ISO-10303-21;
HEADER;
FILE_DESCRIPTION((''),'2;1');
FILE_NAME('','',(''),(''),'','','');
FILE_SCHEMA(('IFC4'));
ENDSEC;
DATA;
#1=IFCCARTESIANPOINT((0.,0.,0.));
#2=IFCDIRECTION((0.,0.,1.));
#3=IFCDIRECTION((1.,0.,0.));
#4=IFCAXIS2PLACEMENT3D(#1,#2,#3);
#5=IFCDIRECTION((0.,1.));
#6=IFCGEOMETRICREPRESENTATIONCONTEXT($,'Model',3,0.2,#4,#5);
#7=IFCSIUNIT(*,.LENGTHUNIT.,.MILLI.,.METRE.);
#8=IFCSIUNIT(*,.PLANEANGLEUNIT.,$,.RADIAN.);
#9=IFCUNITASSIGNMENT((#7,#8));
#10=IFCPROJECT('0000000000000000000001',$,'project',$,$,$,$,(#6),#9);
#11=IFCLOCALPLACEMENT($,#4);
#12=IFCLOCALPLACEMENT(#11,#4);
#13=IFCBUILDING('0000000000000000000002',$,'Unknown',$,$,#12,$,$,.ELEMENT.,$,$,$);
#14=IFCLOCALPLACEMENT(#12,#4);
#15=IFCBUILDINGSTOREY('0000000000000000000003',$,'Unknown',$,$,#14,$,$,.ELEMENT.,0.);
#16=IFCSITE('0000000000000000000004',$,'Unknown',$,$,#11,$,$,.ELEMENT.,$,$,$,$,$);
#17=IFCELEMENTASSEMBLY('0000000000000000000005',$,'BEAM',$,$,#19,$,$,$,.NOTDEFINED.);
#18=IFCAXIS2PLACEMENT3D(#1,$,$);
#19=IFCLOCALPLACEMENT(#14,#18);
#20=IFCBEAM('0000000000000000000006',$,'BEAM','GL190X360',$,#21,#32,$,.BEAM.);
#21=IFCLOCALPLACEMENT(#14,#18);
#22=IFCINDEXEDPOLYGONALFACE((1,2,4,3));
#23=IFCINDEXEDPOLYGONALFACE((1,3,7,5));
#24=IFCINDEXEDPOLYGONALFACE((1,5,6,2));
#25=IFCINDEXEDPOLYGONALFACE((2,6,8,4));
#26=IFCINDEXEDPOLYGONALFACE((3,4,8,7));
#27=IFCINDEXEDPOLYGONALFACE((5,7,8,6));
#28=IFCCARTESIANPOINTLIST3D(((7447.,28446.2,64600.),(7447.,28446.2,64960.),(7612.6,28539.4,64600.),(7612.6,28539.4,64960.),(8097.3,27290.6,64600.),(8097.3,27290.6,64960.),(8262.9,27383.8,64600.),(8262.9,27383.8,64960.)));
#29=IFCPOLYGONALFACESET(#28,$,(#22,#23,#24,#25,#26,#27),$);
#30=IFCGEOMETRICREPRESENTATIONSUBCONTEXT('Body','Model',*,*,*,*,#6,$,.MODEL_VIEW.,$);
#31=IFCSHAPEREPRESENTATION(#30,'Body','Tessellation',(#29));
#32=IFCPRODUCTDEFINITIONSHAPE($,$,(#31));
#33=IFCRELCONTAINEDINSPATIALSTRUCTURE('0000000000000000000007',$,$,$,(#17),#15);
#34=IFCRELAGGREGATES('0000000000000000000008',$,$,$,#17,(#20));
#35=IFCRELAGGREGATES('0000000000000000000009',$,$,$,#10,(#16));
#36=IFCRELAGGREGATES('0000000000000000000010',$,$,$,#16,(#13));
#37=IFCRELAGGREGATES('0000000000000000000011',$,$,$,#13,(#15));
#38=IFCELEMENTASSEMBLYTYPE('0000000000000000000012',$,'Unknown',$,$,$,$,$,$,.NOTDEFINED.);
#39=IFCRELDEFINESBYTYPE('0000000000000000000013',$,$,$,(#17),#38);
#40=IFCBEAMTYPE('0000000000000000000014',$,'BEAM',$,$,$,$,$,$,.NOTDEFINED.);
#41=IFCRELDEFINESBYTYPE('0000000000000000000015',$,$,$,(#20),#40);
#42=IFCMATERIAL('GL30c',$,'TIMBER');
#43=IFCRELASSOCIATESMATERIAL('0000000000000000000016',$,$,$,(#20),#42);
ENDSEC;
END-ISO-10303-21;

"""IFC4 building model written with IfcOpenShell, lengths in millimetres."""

from ifc_helpers import new_model, si_unit, direction, frame, origin_with_axes, place, context, subcontext, project, spatial, polyline, outline, extrude, material, material_profile, profile_set, profile_usage, type_object, element, aggregate, save


model = new_model("IFC4")

# Units and contexts
model_context = context("Model", 3, precision=0.2, world=origin_with_axes(), true_north=direction((0.0, 1.0)))
body_context = subcontext(model_context, "Body", "Model", "MODEL_VIEW")
ifc_project = project(units=[si_unit("LENGTHUNIT", "METRE", prefix="MILLI"), si_unit("PLANEANGLEUNIT", "RADIAN")], contexts=[model_context])

# Site, building, storey
site_placement = place(None, origin_with_axes())
site = spatial("IfcSite", under=ifc_project, at=site_placement, Name="Unknown", CompositionType="ELEMENT")
building_placement = place(site_placement, origin_with_axes())
building = spatial("IfcBuilding", under=site, at=building_placement, Name="Unknown", CompositionType="ELEMENT")
storey_placement = place(building_placement, origin_with_axes())
storey = spatial("IfcBuildingStorey", under=building, at=storey_placement, Name="Unknown", CompositionType="ELEMENT", Elevation=0.0)

# Shared definitions
element_assembly_type = type_object("IfcElementAssemblyType", Name="Unknown", PredefinedType="NOTDEFINED")
ifc_material_1 = material(Name="GL30c", Category="TIMBER")

# Element assembly, beam
ifc_material_profile_1 = material_profile(ifc_material_1, outline(polyline([(-95.0, 180.0), (-95.0, -180.0), (95.0, -180.0), (95.0, 180.0), (-95.0, 180.0)])), Name="GL190X360")
ifc_profile_set_1 = profile_set([ifc_material_profile_1])
ifc_profile_usage_1 = profile_usage(ifc_profile_set_1, cardinal=8)
beam_type_1 = type_object("IfcBeamType", Name="BEAM")
assembly_1_placement = place(storey_placement, frame((7529.8, 28492.8, 64780.0), z_axis=(-0.871487, -0.490418, 0.0), x_axis=(0.490421, -0.871485, 0.0)))
assembly_1 = element("IfcElementAssembly", 1, at=assembly_1_placement, inside=storey, type_object=element_assembly_type, Name="BEAM", PredefinedType="NOTDEFINED")
beam_1_placement = place(assembly_1_placement, origin_with_axes())
beam_1 = element("IfcBeam", 2, at=beam_1_placement, type_object=beam_type_1, material=ifc_profile_usage_1, Name="BEAM", Description="GL190X360", PredefinedType="BEAM", context=body_context, shape_type="SolidModel", body=[
    extrude(outline(polyline([(-95.0, 180.0), (-95.0, -180.0), (95.0, -180.0), (95.0, 180.0), (-95.0, 180.0)])), frame((0.0, 0.0, 0.0), z_axis=(-1.0, 0.0, 0.0), x_axis=(0.0, 0.0, 1.0)), (0.0, 0.0, -1.0), 1326.0),
])
aggregate(assembly_1, [beam_1])

save(model, "model.ifc")
